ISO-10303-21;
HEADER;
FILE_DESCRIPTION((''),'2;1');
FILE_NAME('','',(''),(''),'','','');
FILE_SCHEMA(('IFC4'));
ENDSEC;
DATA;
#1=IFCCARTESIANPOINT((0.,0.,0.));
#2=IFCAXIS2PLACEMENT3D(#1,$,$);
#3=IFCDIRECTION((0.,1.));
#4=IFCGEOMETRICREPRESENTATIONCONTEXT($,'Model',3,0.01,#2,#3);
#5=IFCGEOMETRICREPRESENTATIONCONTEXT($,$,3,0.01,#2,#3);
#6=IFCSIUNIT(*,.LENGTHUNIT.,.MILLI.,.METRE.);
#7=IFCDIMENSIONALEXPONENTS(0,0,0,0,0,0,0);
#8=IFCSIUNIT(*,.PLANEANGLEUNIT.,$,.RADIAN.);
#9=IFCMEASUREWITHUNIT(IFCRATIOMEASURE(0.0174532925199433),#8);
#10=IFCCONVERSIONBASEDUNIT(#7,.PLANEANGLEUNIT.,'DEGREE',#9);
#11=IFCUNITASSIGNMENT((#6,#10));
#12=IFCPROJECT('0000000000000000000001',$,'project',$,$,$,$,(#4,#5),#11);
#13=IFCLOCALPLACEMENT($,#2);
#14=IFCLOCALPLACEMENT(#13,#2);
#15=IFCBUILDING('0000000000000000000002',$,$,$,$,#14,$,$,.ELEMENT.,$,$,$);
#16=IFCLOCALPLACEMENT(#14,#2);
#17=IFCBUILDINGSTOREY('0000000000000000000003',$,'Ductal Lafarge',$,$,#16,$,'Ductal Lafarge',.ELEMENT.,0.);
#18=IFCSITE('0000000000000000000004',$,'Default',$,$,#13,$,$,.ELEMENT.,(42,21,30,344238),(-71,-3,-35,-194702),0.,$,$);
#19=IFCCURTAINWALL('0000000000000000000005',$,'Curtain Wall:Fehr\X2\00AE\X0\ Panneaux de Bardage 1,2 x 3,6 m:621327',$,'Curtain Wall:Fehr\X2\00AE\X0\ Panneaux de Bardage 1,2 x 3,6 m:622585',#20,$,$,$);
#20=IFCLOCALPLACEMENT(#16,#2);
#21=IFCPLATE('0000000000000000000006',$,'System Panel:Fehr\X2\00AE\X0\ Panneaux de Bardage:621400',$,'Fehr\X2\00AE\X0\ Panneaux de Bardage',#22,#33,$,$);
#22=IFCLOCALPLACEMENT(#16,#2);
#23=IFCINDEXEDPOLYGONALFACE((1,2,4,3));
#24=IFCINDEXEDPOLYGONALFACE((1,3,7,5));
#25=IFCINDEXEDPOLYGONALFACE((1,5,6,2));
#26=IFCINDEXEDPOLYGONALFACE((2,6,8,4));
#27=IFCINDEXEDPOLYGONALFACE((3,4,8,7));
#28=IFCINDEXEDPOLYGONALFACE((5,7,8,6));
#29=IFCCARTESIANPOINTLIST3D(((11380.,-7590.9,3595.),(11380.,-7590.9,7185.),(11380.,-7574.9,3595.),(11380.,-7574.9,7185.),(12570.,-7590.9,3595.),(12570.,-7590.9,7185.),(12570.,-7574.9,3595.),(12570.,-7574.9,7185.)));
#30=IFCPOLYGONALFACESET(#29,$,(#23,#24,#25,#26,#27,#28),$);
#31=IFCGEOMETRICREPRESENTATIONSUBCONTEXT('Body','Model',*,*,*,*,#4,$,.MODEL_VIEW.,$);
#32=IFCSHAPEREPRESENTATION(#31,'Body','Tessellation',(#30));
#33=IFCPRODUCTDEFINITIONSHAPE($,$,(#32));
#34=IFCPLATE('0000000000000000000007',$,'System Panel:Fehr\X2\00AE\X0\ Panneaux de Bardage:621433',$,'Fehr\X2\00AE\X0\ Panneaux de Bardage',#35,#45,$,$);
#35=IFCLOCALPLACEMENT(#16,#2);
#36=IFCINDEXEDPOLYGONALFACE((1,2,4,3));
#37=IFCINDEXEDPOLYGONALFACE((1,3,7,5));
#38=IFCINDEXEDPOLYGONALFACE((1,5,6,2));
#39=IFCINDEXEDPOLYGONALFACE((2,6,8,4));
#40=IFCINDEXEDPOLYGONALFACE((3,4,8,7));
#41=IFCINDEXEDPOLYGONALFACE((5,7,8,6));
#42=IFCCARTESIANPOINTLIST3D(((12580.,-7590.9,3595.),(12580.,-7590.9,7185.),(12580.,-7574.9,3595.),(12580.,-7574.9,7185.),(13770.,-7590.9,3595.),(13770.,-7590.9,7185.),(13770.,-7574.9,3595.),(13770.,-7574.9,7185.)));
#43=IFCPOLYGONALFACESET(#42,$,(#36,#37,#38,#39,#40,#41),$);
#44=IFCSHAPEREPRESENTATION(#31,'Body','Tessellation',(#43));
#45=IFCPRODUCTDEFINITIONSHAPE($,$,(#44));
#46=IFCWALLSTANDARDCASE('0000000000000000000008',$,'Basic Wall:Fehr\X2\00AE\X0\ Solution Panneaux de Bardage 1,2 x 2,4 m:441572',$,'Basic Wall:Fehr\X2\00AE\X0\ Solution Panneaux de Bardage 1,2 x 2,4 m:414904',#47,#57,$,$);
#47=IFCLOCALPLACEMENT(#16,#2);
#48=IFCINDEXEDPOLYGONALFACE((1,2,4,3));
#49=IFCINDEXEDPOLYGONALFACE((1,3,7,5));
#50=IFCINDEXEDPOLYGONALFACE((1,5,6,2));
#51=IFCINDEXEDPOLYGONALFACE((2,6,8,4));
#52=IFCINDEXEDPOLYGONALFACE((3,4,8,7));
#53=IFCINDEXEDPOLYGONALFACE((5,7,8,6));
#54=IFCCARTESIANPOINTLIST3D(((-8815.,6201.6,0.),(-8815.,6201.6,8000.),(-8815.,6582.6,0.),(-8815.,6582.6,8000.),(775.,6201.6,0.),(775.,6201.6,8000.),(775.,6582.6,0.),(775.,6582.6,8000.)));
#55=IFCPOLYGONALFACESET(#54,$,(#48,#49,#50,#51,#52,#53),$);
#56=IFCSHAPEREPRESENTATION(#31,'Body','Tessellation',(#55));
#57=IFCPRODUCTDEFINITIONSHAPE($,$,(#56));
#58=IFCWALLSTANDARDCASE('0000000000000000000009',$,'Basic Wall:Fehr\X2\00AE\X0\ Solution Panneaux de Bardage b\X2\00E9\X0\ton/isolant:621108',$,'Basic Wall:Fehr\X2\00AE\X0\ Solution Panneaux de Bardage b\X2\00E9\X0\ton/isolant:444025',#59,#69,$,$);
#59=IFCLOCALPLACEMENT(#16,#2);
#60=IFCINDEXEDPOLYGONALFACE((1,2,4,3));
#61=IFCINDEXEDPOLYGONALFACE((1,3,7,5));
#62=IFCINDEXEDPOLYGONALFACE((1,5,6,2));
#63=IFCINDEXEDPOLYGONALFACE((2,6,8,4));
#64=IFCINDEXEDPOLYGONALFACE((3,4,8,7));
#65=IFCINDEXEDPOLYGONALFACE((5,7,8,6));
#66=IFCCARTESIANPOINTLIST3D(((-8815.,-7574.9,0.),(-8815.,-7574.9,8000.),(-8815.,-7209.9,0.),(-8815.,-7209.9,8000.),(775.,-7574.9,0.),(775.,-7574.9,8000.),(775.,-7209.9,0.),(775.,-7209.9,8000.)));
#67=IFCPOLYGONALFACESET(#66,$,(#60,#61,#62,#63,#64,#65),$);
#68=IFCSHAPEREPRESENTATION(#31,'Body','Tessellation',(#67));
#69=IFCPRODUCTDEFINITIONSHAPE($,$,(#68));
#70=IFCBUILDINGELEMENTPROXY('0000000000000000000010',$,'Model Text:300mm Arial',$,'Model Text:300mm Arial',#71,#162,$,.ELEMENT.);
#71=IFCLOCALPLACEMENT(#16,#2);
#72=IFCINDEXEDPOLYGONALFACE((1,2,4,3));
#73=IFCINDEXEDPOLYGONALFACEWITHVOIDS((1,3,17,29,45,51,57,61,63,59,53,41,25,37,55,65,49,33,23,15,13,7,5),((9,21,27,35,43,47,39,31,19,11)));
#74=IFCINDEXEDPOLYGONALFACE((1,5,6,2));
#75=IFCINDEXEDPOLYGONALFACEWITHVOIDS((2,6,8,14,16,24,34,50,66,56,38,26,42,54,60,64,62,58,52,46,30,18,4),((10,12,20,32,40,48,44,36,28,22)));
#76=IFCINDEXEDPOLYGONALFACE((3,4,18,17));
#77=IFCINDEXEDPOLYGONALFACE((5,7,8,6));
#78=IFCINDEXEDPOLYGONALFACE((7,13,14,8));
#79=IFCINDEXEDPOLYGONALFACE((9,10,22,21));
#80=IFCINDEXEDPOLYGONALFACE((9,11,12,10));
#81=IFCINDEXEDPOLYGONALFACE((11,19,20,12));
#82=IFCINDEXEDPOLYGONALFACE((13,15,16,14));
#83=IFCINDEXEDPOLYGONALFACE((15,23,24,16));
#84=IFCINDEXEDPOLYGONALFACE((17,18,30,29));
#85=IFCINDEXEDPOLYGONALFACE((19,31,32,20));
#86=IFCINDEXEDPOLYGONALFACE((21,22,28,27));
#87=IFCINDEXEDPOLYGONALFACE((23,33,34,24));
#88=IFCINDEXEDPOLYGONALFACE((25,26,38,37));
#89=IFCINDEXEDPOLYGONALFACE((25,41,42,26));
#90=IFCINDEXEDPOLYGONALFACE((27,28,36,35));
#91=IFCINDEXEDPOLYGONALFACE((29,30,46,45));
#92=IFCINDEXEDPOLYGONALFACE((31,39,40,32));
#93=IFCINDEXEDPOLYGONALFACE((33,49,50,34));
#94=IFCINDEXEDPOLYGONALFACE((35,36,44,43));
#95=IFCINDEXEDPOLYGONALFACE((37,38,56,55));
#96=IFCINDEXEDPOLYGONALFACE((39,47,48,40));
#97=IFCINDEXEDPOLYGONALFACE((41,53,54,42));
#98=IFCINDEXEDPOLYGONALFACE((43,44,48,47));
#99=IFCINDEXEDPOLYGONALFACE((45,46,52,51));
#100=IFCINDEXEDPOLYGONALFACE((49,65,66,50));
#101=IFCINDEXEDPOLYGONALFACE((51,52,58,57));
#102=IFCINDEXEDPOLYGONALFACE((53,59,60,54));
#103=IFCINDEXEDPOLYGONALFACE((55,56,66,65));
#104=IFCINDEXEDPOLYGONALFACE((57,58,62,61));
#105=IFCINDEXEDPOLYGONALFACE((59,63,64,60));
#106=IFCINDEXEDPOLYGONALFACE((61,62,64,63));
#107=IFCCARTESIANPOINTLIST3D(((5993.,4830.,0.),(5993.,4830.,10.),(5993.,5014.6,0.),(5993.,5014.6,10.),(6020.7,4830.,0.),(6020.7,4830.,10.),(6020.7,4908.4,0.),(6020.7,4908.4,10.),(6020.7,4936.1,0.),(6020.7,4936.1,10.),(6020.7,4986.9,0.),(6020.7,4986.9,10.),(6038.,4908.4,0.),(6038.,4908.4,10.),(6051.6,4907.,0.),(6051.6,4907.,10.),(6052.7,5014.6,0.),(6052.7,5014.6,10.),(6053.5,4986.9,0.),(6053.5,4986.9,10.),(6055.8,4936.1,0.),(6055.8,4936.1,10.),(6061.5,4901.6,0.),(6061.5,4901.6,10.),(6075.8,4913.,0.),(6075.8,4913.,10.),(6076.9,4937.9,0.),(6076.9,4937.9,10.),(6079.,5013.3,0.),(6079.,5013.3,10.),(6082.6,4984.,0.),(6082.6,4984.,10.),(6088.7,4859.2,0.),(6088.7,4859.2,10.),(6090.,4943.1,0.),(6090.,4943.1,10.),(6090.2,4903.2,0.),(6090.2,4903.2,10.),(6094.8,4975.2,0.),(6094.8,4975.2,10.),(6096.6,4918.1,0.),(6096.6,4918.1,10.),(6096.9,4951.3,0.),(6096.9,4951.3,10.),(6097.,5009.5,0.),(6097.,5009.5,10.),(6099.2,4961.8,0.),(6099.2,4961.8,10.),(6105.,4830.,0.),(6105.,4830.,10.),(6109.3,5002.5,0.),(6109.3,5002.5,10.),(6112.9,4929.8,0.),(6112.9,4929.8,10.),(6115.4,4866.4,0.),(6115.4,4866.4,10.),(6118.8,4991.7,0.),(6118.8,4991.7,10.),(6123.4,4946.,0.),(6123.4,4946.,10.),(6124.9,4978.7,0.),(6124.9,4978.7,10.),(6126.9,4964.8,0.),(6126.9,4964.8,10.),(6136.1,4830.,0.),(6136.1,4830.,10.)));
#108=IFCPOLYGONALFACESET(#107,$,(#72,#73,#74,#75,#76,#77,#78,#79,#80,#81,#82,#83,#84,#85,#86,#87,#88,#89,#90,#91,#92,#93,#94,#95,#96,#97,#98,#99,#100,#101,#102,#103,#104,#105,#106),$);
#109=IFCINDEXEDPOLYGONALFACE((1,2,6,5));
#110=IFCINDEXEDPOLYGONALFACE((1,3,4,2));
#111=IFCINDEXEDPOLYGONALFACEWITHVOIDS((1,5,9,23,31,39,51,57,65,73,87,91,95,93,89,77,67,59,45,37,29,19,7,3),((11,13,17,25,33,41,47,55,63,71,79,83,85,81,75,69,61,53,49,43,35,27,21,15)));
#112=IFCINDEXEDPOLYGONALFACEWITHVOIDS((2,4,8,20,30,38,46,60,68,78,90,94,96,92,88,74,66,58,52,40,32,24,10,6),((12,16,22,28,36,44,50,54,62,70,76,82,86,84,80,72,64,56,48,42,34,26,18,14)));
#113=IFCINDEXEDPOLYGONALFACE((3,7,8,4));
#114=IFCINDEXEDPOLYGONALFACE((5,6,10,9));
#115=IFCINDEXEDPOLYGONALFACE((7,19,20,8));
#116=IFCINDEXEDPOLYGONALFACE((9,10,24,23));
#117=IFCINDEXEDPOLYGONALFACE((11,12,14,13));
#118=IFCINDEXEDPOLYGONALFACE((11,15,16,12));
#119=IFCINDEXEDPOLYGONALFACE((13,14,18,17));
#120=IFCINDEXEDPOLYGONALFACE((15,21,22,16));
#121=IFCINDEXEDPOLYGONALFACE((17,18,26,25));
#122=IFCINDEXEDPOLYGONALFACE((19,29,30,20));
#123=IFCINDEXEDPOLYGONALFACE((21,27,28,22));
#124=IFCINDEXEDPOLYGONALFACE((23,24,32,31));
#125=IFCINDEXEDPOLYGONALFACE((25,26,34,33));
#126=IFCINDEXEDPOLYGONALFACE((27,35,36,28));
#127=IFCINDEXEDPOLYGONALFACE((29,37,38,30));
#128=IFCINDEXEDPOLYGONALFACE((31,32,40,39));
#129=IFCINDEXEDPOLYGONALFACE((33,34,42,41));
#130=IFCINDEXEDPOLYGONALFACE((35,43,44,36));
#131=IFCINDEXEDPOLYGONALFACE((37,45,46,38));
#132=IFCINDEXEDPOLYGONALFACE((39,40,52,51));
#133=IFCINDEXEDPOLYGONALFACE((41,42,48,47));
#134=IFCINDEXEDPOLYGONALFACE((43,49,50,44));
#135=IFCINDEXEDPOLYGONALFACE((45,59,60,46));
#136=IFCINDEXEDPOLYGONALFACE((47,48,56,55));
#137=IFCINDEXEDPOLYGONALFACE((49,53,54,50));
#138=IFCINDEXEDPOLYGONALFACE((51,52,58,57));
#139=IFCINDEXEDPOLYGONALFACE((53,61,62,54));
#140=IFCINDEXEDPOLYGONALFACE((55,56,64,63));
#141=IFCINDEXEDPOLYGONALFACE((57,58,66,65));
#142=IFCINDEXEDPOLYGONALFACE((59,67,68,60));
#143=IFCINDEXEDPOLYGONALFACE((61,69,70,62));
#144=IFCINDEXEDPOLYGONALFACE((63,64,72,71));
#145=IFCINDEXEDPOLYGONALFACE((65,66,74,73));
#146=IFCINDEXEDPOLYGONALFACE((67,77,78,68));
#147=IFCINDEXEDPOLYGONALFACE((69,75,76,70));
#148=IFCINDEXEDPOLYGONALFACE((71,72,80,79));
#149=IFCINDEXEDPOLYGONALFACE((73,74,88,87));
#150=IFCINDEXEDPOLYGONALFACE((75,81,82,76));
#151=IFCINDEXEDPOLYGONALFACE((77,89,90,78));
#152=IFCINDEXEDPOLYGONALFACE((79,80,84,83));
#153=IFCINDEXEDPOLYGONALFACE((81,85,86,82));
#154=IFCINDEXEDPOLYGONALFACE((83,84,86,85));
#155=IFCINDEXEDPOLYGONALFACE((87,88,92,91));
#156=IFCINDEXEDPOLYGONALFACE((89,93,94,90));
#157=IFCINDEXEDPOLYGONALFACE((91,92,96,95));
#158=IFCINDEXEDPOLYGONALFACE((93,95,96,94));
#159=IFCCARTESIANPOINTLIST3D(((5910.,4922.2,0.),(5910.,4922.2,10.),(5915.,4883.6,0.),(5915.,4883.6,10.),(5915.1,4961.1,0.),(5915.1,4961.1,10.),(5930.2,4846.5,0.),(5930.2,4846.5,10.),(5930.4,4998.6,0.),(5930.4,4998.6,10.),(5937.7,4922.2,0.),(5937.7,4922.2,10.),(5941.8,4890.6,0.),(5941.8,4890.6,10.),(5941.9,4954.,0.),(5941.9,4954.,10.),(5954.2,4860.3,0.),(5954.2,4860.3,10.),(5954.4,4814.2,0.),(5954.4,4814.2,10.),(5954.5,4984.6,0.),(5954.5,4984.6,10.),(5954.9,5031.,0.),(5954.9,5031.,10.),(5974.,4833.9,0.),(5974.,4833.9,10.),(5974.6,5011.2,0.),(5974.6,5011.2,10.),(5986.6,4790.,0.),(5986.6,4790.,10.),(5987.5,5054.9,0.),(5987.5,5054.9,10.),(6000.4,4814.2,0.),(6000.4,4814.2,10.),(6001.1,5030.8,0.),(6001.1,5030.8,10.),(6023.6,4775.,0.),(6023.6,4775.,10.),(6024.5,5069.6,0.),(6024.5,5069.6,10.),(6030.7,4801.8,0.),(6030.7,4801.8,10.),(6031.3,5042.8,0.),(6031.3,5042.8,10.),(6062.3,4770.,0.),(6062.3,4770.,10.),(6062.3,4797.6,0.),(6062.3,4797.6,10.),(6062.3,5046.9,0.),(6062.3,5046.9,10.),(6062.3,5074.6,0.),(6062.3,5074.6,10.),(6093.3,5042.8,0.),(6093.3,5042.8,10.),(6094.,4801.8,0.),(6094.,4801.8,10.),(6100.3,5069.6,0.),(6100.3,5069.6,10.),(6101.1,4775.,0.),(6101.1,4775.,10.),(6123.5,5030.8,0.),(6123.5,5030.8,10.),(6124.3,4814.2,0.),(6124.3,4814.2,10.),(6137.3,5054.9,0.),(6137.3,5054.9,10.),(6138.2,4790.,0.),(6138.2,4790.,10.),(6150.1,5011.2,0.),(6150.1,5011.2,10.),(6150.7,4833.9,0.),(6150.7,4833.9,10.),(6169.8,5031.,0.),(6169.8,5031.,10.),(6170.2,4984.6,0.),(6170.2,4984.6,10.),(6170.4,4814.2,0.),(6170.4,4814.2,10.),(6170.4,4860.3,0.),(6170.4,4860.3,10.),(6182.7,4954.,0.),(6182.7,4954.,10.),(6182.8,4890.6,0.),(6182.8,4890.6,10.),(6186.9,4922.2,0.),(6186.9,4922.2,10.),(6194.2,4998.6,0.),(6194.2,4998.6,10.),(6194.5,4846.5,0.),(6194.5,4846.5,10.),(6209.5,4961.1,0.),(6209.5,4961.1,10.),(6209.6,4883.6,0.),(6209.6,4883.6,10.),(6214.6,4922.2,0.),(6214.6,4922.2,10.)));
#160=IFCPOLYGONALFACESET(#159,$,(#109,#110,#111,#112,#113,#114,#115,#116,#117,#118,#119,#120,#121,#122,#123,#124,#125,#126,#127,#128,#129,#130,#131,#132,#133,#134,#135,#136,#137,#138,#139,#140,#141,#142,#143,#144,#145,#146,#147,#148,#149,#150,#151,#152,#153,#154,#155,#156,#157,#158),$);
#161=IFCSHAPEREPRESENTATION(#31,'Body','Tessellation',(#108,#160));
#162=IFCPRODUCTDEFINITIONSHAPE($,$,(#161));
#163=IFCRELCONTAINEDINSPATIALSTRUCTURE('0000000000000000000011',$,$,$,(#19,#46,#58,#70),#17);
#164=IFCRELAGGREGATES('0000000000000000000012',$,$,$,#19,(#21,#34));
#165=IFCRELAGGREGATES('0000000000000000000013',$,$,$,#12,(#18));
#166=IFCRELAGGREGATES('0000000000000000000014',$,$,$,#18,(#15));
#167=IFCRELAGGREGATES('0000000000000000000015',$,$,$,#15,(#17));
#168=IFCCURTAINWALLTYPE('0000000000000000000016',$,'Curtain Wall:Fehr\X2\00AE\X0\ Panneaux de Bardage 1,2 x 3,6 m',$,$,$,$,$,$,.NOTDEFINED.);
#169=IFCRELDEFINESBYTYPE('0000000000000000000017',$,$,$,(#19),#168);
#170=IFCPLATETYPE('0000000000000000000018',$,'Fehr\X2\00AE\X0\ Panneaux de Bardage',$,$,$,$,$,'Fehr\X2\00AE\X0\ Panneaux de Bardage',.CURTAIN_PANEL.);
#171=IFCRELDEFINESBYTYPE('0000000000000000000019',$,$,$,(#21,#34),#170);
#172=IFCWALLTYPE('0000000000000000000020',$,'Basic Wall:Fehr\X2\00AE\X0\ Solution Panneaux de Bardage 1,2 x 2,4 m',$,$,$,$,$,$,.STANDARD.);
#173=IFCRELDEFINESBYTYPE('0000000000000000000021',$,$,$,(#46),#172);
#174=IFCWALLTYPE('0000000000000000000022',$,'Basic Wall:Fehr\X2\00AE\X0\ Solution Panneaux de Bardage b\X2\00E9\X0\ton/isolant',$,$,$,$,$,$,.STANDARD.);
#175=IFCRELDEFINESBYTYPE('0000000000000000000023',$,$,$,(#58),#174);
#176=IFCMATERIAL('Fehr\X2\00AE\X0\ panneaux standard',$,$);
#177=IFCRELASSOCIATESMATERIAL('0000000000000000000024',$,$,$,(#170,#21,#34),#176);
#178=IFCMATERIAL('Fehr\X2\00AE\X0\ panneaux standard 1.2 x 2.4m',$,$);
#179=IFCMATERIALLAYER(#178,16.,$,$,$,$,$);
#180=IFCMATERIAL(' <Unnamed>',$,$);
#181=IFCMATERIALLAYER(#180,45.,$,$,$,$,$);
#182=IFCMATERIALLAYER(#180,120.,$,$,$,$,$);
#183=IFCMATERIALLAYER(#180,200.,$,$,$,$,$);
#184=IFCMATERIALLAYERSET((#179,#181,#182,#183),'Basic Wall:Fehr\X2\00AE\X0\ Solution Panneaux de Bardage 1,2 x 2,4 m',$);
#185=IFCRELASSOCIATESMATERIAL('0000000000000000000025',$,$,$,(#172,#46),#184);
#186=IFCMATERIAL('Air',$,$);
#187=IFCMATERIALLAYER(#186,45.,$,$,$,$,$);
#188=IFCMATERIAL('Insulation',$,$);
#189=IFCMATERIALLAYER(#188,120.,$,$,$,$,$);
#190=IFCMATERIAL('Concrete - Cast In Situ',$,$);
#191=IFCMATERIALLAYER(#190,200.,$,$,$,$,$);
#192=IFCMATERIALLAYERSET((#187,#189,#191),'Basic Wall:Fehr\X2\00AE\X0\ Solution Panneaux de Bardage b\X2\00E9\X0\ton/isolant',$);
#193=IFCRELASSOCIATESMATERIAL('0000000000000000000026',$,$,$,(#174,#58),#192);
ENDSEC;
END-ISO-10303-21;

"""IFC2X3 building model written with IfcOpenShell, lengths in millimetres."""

from ifc_helpers import new_model, entity, si_unit, converted_unit, direction, frame, frame_2d, origin, origin_2d_with_axis, place, context, subcontext, project, spatial, polyline, rectangle, outline, extrude, source, transform, mapped, material, layer, layer_set, layer_usage, type_object, type_shapes, element, aggregate, save


model = new_model("IFC2X3")

# Units and contexts
model_context = context("Model", 3, precision=0.01, world=origin(), true_north=direction((0.0, 1.0)))
context_of_model = context(None, 3, precision=0.01, world=origin(), true_north=direction((0.0, 1.0)))
body_context = subcontext(model_context, "Body", "Model", "MODEL_VIEW")
ifc_project = project(units=[si_unit("LENGTHUNIT", "METRE", prefix="MILLI"), converted_unit("PLANEANGLEUNIT", "DEGREE", entity("IfcRatioMeasure", 0.0174532925199433), si_unit("PLANEANGLEUNIT", "RADIAN"), dimensions=[0, 0, 0, 0, 0, 0, 0])], contexts=[model_context, context_of_model])

# Site, building, storey
site_placement = place(None, origin())
site = spatial("IfcSite", under=ifc_project, at=site_placement, Name="Default", CompositionType="ELEMENT", RefLatitude=(42, 21, 30, 344238), RefLongitude=(-71, -3, -35, -194702), RefElevation=0.0)
building_placement = place(site_placement, origin())
building = spatial("IfcBuilding", under=site, at=building_placement, CompositionType="ELEMENT")
storey_placement = place(building_placement, origin())
storey = spatial("IfcBuildingStorey", under=building, at=storey_placement, Name="Ductal Lafarge", LongName="Ductal Lafarge", CompositionType="ELEMENT", Elevation=0.0)

# Curtain wall
curtain_wall_type_1 = type_object("IfcCurtainWallType", Name="Curtain Wall:Fehr® Panneaux de Bardage 1,2 x 3,6 m", PredefinedType="NOTDEFINED")
curtain_wall_1_placement = place(storey_placement, origin())
curtain_wall_1 = element("IfcCurtainWall", 1, at=curtain_wall_1_placement, inside=storey, type_object=curtain_wall_type_1, Name="Curtain Wall:Fehr® Panneaux de Bardage 1,2 x 3,6 m:621327", ObjectType="Curtain Wall:Fehr® Panneaux de Bardage 1,2 x 3,6 m:622585")
ifc_material_1 = material(Name="Fehr® panneaux standard")

# Plates
plate_type_1 = type_object("IfcPlateType", Name="Fehr® Panneaux de Bardage", ElementType="Fehr® Panneaux de Bardage", PredefinedType="CURTAIN_PANEL", material=ifc_material_1)
shared_shape_1 = source(origin(), body_context, "Body", "SweptSolid", [
    extrude(rectangle(XDim=16.0, YDim=1190.0, at=origin_2d_with_axis()), frame((0.0, 0.0, 0.0), z_axis=(0.0, 0.0, 1.0), x_axis=(0.0, 1.0, 0.0)), (0.0, 0.0, 1.0), 3590.0),
])
type_shapes(plate_type_1, [shared_shape_1])
plate_1_placement = place(curtain_wall_1_placement, frame((11975.0, -7582.9, 3595.0)))
plate_1 = element("IfcPlate", 2, at=plate_1_placement, type_object=plate_type_1, material=ifc_material_1, Name="System Panel:Fehr® Panneaux de Bardage:621400", ObjectType="Fehr® Panneaux de Bardage", context=body_context, shape_type="MappedRepresentation", body=[
    mapped(shared_shape_1, transform((0.0, 0.0, 0.0), scale=1.0)),
])
plate_2_placement = place(curtain_wall_1_placement, frame((13175.0, -7582.9, 3595.0)))
plate_2 = element("IfcPlate", 3, at=plate_2_placement, type_object=plate_type_1, material=ifc_material_1, Name="System Panel:Fehr® Panneaux de Bardage:621433", ObjectType="Fehr® Panneaux de Bardage", context=body_context, shape_type="MappedRepresentation", body=[
    mapped(shared_shape_1, transform((0.0, 0.0, 0.0), scale=1.0)),
])
aggregate(curtain_wall_1, [plate_1, plate_2])

# Walls
ifc_material_2 = material(Name="Fehr® panneaux standard 1.2 x 2.4m")
ifc_layer_1 = layer(ifc_material_2, 16.0)
ifc_material_3 = material(Name=" <Unnamed>")
ifc_layer_2 = layer(ifc_material_3, 45.0)
ifc_layer_3 = layer(ifc_material_3, 120.0)
ifc_layer_4 = layer(ifc_material_3, 200.0)
ifc_layer_set_1 = layer_set([ifc_layer_1, ifc_layer_2, ifc_layer_3, ifc_layer_4], Name="Basic Wall:Fehr® Solution Panneaux de Bardage 1,2 x 2,4 m")
ifc_layer_usage_1 = layer_usage(ifc_layer_set_1, "AXIS2", "NEGATIVE", 190.5)
wall_type_1 = type_object("IfcWallType", Name="Basic Wall:Fehr® Solution Panneaux de Bardage 1,2 x 2,4 m", PredefinedType="STANDARD", material=ifc_layer_set_1)
wall_1_placement = place(storey_placement, frame((775.0, 6392.1, 0.0), z_axis=(0.0, 0.0, 1.0), x_axis=(-1.0, 0.0, 0.0)))
element("IfcWallStandardCase", 4, at=wall_1_placement, inside=storey, type_object=wall_type_1, material=ifc_layer_usage_1, Name="Basic Wall:Fehr® Solution Panneaux de Bardage 1,2 x 2,4 m:441572", ObjectType="Basic Wall:Fehr® Solution Panneaux de Bardage 1,2 x 2,4 m:414904", context=body_context, shape_type="SweptSolid", body=[
    extrude(rectangle(XDim=9590.0, YDim=381.0, at=frame_2d((4795.0, 0.0), x_axis=(-1.0, 0.0))), origin(), (0.0, 0.0, 1.0), 8000.0),
])
ifc_material_4 = material(Name="Air")
ifc_layer_5 = layer(ifc_material_4, 45.0)
ifc_material_5 = material(Name="Insulation")
ifc_layer_6 = layer(ifc_material_5, 120.0)
ifc_material_6 = material(Name="Concrete - Cast In Situ")
ifc_layer_7 = layer(ifc_material_6, 200.0)
ifc_layer_set_2 = layer_set([ifc_layer_5, ifc_layer_6, ifc_layer_7], Name="Basic Wall:Fehr® Solution Panneaux de Bardage béton/isolant")
ifc_layer_usage_2 = layer_usage(ifc_layer_set_2, "AXIS2", "NEGATIVE", 182.5)
wall_type_2 = type_object("IfcWallType", Name="Basic Wall:Fehr® Solution Panneaux de Bardage béton/isolant", PredefinedType="STANDARD", material=ifc_layer_set_2)
wall_2_placement = place(storey_placement, frame((775.0, -7392.4, 0.0), z_axis=(0.0, 0.0, 1.0), x_axis=(-1.0, 0.0, 0.0)))
element("IfcWallStandardCase", 5, at=wall_2_placement, inside=storey, type_object=wall_type_2, material=ifc_layer_usage_2, Name="Basic Wall:Fehr® Solution Panneaux de Bardage béton/isolant:621108", ObjectType="Basic Wall:Fehr® Solution Panneaux de Bardage béton/isolant:444025", context=body_context, shape_type="SweptSolid", body=[
    extrude(rectangle(XDim=9590.0, YDim=365.0, at=frame_2d((4795.0, 0.0), x_axis=(-1.0, 0.0))), origin(), (0.0, 0.0, 1.0), 8000.0),
])

# Building element proxy
proxy_1_placement = place(storey_placement, frame((5910.0, 4770.0, 0.0)))
element("IfcBuildingElementProxy", 6, at=proxy_1_placement, inside=storey, Name="Model Text:300mm Arial", ObjectType="Model Text:300mm Arial", CompositionType="ELEMENT", context=body_context, shape_type="SweptSolid", body=[
    extrude(outline(polyline([(-86.6, -94.9), (-58.9, -94.9), (-58.9, -16.4), (-41.7, -16.4), (-28.0, -17.8), (-18.1, -23.2), (9.1, -65.6), (25.3, -94.9), (56.5, -94.9), (35.8, -58.4), (10.6, -21.6), (-3.8, -11.8), (17.0, -6.7), (33.3, 5.0), (43.8, 21.2), (47.3, 40.0), (45.2, 53.9), (39.1, 66.9), (29.6, 77.7), (17.3, 84.7), (-0.6, 88.5), (-26.9, 89.8), (-86.6, 89.8), (-86.6, -94.9)]), holes=[polyline([(-58.9, 11.3), (-58.9, 62.1), (-26.1, 62.1), (2.9, 59.2), (15.2, 50.4), (19.6, 37.0), (17.3, 26.5), (10.4, 18.3), (-2.7, 13.1), (-23.8, 11.3), (-58.9, 11.3)])]), frame((169.7, 154.9, 0.0)), (0.0, 0.0, 1.0), 10.0),
    extrude(outline(polyline([(-19.6, -150.9), (18.6, -150.9), (57.1, -141.0), (92.5, -121.5), (121.0, -92.5), (141.0, -57.4), (151.1, -19.4), (151.1, 19.5), (140.9, 58.3), (121.0, 93.4), (92.2, 121.5), (57.4, 141.2), (19.6, 151.2), (-19.4, 151.2), (-58.1, 141.0), (-93.2, 121.2), (-121.3, 92.3), (-141.0, 57.5), (-150.9, 19.8), (-150.9, -19.4), (-140.6, -58.5), (-120.5, -93.8), (-91.4, -121.7), (-56.6, -141.1), (-19.6, -150.9)]), holes=[polyline([(-16.1, -123.4), (-46.2, -115.4), (-74.7, -99.6), (-98.5, -76.7), (-114.9, -47.8), (-123.4, -15.8), (-123.5, 16.3), (-115.3, 47.1), (-99.2, 75.5), (-76.2, 99.1), (-47.5, 115.3), (-15.8, 123.7), (16.1, 123.7), (46.9, 115.6), (75.4, 99.4), (99.0, 76.3), (115.3, 47.7), (123.7, 16.0), (123.7, -15.9), (115.4, -46.9), (98.9, -75.6), (75.6, -99.3), (46.7, -115.3), (15.2, -123.4), (-16.1, -123.4)])]), frame((152.4, 152.5, 0.0), z_axis=(0.0, 0.0, 1.0), x_axis=(-0.991656, -0.128915, 0.0)), (0.0, 0.0, 1.0), 10.0),
])

save(model, "model.ifc")
